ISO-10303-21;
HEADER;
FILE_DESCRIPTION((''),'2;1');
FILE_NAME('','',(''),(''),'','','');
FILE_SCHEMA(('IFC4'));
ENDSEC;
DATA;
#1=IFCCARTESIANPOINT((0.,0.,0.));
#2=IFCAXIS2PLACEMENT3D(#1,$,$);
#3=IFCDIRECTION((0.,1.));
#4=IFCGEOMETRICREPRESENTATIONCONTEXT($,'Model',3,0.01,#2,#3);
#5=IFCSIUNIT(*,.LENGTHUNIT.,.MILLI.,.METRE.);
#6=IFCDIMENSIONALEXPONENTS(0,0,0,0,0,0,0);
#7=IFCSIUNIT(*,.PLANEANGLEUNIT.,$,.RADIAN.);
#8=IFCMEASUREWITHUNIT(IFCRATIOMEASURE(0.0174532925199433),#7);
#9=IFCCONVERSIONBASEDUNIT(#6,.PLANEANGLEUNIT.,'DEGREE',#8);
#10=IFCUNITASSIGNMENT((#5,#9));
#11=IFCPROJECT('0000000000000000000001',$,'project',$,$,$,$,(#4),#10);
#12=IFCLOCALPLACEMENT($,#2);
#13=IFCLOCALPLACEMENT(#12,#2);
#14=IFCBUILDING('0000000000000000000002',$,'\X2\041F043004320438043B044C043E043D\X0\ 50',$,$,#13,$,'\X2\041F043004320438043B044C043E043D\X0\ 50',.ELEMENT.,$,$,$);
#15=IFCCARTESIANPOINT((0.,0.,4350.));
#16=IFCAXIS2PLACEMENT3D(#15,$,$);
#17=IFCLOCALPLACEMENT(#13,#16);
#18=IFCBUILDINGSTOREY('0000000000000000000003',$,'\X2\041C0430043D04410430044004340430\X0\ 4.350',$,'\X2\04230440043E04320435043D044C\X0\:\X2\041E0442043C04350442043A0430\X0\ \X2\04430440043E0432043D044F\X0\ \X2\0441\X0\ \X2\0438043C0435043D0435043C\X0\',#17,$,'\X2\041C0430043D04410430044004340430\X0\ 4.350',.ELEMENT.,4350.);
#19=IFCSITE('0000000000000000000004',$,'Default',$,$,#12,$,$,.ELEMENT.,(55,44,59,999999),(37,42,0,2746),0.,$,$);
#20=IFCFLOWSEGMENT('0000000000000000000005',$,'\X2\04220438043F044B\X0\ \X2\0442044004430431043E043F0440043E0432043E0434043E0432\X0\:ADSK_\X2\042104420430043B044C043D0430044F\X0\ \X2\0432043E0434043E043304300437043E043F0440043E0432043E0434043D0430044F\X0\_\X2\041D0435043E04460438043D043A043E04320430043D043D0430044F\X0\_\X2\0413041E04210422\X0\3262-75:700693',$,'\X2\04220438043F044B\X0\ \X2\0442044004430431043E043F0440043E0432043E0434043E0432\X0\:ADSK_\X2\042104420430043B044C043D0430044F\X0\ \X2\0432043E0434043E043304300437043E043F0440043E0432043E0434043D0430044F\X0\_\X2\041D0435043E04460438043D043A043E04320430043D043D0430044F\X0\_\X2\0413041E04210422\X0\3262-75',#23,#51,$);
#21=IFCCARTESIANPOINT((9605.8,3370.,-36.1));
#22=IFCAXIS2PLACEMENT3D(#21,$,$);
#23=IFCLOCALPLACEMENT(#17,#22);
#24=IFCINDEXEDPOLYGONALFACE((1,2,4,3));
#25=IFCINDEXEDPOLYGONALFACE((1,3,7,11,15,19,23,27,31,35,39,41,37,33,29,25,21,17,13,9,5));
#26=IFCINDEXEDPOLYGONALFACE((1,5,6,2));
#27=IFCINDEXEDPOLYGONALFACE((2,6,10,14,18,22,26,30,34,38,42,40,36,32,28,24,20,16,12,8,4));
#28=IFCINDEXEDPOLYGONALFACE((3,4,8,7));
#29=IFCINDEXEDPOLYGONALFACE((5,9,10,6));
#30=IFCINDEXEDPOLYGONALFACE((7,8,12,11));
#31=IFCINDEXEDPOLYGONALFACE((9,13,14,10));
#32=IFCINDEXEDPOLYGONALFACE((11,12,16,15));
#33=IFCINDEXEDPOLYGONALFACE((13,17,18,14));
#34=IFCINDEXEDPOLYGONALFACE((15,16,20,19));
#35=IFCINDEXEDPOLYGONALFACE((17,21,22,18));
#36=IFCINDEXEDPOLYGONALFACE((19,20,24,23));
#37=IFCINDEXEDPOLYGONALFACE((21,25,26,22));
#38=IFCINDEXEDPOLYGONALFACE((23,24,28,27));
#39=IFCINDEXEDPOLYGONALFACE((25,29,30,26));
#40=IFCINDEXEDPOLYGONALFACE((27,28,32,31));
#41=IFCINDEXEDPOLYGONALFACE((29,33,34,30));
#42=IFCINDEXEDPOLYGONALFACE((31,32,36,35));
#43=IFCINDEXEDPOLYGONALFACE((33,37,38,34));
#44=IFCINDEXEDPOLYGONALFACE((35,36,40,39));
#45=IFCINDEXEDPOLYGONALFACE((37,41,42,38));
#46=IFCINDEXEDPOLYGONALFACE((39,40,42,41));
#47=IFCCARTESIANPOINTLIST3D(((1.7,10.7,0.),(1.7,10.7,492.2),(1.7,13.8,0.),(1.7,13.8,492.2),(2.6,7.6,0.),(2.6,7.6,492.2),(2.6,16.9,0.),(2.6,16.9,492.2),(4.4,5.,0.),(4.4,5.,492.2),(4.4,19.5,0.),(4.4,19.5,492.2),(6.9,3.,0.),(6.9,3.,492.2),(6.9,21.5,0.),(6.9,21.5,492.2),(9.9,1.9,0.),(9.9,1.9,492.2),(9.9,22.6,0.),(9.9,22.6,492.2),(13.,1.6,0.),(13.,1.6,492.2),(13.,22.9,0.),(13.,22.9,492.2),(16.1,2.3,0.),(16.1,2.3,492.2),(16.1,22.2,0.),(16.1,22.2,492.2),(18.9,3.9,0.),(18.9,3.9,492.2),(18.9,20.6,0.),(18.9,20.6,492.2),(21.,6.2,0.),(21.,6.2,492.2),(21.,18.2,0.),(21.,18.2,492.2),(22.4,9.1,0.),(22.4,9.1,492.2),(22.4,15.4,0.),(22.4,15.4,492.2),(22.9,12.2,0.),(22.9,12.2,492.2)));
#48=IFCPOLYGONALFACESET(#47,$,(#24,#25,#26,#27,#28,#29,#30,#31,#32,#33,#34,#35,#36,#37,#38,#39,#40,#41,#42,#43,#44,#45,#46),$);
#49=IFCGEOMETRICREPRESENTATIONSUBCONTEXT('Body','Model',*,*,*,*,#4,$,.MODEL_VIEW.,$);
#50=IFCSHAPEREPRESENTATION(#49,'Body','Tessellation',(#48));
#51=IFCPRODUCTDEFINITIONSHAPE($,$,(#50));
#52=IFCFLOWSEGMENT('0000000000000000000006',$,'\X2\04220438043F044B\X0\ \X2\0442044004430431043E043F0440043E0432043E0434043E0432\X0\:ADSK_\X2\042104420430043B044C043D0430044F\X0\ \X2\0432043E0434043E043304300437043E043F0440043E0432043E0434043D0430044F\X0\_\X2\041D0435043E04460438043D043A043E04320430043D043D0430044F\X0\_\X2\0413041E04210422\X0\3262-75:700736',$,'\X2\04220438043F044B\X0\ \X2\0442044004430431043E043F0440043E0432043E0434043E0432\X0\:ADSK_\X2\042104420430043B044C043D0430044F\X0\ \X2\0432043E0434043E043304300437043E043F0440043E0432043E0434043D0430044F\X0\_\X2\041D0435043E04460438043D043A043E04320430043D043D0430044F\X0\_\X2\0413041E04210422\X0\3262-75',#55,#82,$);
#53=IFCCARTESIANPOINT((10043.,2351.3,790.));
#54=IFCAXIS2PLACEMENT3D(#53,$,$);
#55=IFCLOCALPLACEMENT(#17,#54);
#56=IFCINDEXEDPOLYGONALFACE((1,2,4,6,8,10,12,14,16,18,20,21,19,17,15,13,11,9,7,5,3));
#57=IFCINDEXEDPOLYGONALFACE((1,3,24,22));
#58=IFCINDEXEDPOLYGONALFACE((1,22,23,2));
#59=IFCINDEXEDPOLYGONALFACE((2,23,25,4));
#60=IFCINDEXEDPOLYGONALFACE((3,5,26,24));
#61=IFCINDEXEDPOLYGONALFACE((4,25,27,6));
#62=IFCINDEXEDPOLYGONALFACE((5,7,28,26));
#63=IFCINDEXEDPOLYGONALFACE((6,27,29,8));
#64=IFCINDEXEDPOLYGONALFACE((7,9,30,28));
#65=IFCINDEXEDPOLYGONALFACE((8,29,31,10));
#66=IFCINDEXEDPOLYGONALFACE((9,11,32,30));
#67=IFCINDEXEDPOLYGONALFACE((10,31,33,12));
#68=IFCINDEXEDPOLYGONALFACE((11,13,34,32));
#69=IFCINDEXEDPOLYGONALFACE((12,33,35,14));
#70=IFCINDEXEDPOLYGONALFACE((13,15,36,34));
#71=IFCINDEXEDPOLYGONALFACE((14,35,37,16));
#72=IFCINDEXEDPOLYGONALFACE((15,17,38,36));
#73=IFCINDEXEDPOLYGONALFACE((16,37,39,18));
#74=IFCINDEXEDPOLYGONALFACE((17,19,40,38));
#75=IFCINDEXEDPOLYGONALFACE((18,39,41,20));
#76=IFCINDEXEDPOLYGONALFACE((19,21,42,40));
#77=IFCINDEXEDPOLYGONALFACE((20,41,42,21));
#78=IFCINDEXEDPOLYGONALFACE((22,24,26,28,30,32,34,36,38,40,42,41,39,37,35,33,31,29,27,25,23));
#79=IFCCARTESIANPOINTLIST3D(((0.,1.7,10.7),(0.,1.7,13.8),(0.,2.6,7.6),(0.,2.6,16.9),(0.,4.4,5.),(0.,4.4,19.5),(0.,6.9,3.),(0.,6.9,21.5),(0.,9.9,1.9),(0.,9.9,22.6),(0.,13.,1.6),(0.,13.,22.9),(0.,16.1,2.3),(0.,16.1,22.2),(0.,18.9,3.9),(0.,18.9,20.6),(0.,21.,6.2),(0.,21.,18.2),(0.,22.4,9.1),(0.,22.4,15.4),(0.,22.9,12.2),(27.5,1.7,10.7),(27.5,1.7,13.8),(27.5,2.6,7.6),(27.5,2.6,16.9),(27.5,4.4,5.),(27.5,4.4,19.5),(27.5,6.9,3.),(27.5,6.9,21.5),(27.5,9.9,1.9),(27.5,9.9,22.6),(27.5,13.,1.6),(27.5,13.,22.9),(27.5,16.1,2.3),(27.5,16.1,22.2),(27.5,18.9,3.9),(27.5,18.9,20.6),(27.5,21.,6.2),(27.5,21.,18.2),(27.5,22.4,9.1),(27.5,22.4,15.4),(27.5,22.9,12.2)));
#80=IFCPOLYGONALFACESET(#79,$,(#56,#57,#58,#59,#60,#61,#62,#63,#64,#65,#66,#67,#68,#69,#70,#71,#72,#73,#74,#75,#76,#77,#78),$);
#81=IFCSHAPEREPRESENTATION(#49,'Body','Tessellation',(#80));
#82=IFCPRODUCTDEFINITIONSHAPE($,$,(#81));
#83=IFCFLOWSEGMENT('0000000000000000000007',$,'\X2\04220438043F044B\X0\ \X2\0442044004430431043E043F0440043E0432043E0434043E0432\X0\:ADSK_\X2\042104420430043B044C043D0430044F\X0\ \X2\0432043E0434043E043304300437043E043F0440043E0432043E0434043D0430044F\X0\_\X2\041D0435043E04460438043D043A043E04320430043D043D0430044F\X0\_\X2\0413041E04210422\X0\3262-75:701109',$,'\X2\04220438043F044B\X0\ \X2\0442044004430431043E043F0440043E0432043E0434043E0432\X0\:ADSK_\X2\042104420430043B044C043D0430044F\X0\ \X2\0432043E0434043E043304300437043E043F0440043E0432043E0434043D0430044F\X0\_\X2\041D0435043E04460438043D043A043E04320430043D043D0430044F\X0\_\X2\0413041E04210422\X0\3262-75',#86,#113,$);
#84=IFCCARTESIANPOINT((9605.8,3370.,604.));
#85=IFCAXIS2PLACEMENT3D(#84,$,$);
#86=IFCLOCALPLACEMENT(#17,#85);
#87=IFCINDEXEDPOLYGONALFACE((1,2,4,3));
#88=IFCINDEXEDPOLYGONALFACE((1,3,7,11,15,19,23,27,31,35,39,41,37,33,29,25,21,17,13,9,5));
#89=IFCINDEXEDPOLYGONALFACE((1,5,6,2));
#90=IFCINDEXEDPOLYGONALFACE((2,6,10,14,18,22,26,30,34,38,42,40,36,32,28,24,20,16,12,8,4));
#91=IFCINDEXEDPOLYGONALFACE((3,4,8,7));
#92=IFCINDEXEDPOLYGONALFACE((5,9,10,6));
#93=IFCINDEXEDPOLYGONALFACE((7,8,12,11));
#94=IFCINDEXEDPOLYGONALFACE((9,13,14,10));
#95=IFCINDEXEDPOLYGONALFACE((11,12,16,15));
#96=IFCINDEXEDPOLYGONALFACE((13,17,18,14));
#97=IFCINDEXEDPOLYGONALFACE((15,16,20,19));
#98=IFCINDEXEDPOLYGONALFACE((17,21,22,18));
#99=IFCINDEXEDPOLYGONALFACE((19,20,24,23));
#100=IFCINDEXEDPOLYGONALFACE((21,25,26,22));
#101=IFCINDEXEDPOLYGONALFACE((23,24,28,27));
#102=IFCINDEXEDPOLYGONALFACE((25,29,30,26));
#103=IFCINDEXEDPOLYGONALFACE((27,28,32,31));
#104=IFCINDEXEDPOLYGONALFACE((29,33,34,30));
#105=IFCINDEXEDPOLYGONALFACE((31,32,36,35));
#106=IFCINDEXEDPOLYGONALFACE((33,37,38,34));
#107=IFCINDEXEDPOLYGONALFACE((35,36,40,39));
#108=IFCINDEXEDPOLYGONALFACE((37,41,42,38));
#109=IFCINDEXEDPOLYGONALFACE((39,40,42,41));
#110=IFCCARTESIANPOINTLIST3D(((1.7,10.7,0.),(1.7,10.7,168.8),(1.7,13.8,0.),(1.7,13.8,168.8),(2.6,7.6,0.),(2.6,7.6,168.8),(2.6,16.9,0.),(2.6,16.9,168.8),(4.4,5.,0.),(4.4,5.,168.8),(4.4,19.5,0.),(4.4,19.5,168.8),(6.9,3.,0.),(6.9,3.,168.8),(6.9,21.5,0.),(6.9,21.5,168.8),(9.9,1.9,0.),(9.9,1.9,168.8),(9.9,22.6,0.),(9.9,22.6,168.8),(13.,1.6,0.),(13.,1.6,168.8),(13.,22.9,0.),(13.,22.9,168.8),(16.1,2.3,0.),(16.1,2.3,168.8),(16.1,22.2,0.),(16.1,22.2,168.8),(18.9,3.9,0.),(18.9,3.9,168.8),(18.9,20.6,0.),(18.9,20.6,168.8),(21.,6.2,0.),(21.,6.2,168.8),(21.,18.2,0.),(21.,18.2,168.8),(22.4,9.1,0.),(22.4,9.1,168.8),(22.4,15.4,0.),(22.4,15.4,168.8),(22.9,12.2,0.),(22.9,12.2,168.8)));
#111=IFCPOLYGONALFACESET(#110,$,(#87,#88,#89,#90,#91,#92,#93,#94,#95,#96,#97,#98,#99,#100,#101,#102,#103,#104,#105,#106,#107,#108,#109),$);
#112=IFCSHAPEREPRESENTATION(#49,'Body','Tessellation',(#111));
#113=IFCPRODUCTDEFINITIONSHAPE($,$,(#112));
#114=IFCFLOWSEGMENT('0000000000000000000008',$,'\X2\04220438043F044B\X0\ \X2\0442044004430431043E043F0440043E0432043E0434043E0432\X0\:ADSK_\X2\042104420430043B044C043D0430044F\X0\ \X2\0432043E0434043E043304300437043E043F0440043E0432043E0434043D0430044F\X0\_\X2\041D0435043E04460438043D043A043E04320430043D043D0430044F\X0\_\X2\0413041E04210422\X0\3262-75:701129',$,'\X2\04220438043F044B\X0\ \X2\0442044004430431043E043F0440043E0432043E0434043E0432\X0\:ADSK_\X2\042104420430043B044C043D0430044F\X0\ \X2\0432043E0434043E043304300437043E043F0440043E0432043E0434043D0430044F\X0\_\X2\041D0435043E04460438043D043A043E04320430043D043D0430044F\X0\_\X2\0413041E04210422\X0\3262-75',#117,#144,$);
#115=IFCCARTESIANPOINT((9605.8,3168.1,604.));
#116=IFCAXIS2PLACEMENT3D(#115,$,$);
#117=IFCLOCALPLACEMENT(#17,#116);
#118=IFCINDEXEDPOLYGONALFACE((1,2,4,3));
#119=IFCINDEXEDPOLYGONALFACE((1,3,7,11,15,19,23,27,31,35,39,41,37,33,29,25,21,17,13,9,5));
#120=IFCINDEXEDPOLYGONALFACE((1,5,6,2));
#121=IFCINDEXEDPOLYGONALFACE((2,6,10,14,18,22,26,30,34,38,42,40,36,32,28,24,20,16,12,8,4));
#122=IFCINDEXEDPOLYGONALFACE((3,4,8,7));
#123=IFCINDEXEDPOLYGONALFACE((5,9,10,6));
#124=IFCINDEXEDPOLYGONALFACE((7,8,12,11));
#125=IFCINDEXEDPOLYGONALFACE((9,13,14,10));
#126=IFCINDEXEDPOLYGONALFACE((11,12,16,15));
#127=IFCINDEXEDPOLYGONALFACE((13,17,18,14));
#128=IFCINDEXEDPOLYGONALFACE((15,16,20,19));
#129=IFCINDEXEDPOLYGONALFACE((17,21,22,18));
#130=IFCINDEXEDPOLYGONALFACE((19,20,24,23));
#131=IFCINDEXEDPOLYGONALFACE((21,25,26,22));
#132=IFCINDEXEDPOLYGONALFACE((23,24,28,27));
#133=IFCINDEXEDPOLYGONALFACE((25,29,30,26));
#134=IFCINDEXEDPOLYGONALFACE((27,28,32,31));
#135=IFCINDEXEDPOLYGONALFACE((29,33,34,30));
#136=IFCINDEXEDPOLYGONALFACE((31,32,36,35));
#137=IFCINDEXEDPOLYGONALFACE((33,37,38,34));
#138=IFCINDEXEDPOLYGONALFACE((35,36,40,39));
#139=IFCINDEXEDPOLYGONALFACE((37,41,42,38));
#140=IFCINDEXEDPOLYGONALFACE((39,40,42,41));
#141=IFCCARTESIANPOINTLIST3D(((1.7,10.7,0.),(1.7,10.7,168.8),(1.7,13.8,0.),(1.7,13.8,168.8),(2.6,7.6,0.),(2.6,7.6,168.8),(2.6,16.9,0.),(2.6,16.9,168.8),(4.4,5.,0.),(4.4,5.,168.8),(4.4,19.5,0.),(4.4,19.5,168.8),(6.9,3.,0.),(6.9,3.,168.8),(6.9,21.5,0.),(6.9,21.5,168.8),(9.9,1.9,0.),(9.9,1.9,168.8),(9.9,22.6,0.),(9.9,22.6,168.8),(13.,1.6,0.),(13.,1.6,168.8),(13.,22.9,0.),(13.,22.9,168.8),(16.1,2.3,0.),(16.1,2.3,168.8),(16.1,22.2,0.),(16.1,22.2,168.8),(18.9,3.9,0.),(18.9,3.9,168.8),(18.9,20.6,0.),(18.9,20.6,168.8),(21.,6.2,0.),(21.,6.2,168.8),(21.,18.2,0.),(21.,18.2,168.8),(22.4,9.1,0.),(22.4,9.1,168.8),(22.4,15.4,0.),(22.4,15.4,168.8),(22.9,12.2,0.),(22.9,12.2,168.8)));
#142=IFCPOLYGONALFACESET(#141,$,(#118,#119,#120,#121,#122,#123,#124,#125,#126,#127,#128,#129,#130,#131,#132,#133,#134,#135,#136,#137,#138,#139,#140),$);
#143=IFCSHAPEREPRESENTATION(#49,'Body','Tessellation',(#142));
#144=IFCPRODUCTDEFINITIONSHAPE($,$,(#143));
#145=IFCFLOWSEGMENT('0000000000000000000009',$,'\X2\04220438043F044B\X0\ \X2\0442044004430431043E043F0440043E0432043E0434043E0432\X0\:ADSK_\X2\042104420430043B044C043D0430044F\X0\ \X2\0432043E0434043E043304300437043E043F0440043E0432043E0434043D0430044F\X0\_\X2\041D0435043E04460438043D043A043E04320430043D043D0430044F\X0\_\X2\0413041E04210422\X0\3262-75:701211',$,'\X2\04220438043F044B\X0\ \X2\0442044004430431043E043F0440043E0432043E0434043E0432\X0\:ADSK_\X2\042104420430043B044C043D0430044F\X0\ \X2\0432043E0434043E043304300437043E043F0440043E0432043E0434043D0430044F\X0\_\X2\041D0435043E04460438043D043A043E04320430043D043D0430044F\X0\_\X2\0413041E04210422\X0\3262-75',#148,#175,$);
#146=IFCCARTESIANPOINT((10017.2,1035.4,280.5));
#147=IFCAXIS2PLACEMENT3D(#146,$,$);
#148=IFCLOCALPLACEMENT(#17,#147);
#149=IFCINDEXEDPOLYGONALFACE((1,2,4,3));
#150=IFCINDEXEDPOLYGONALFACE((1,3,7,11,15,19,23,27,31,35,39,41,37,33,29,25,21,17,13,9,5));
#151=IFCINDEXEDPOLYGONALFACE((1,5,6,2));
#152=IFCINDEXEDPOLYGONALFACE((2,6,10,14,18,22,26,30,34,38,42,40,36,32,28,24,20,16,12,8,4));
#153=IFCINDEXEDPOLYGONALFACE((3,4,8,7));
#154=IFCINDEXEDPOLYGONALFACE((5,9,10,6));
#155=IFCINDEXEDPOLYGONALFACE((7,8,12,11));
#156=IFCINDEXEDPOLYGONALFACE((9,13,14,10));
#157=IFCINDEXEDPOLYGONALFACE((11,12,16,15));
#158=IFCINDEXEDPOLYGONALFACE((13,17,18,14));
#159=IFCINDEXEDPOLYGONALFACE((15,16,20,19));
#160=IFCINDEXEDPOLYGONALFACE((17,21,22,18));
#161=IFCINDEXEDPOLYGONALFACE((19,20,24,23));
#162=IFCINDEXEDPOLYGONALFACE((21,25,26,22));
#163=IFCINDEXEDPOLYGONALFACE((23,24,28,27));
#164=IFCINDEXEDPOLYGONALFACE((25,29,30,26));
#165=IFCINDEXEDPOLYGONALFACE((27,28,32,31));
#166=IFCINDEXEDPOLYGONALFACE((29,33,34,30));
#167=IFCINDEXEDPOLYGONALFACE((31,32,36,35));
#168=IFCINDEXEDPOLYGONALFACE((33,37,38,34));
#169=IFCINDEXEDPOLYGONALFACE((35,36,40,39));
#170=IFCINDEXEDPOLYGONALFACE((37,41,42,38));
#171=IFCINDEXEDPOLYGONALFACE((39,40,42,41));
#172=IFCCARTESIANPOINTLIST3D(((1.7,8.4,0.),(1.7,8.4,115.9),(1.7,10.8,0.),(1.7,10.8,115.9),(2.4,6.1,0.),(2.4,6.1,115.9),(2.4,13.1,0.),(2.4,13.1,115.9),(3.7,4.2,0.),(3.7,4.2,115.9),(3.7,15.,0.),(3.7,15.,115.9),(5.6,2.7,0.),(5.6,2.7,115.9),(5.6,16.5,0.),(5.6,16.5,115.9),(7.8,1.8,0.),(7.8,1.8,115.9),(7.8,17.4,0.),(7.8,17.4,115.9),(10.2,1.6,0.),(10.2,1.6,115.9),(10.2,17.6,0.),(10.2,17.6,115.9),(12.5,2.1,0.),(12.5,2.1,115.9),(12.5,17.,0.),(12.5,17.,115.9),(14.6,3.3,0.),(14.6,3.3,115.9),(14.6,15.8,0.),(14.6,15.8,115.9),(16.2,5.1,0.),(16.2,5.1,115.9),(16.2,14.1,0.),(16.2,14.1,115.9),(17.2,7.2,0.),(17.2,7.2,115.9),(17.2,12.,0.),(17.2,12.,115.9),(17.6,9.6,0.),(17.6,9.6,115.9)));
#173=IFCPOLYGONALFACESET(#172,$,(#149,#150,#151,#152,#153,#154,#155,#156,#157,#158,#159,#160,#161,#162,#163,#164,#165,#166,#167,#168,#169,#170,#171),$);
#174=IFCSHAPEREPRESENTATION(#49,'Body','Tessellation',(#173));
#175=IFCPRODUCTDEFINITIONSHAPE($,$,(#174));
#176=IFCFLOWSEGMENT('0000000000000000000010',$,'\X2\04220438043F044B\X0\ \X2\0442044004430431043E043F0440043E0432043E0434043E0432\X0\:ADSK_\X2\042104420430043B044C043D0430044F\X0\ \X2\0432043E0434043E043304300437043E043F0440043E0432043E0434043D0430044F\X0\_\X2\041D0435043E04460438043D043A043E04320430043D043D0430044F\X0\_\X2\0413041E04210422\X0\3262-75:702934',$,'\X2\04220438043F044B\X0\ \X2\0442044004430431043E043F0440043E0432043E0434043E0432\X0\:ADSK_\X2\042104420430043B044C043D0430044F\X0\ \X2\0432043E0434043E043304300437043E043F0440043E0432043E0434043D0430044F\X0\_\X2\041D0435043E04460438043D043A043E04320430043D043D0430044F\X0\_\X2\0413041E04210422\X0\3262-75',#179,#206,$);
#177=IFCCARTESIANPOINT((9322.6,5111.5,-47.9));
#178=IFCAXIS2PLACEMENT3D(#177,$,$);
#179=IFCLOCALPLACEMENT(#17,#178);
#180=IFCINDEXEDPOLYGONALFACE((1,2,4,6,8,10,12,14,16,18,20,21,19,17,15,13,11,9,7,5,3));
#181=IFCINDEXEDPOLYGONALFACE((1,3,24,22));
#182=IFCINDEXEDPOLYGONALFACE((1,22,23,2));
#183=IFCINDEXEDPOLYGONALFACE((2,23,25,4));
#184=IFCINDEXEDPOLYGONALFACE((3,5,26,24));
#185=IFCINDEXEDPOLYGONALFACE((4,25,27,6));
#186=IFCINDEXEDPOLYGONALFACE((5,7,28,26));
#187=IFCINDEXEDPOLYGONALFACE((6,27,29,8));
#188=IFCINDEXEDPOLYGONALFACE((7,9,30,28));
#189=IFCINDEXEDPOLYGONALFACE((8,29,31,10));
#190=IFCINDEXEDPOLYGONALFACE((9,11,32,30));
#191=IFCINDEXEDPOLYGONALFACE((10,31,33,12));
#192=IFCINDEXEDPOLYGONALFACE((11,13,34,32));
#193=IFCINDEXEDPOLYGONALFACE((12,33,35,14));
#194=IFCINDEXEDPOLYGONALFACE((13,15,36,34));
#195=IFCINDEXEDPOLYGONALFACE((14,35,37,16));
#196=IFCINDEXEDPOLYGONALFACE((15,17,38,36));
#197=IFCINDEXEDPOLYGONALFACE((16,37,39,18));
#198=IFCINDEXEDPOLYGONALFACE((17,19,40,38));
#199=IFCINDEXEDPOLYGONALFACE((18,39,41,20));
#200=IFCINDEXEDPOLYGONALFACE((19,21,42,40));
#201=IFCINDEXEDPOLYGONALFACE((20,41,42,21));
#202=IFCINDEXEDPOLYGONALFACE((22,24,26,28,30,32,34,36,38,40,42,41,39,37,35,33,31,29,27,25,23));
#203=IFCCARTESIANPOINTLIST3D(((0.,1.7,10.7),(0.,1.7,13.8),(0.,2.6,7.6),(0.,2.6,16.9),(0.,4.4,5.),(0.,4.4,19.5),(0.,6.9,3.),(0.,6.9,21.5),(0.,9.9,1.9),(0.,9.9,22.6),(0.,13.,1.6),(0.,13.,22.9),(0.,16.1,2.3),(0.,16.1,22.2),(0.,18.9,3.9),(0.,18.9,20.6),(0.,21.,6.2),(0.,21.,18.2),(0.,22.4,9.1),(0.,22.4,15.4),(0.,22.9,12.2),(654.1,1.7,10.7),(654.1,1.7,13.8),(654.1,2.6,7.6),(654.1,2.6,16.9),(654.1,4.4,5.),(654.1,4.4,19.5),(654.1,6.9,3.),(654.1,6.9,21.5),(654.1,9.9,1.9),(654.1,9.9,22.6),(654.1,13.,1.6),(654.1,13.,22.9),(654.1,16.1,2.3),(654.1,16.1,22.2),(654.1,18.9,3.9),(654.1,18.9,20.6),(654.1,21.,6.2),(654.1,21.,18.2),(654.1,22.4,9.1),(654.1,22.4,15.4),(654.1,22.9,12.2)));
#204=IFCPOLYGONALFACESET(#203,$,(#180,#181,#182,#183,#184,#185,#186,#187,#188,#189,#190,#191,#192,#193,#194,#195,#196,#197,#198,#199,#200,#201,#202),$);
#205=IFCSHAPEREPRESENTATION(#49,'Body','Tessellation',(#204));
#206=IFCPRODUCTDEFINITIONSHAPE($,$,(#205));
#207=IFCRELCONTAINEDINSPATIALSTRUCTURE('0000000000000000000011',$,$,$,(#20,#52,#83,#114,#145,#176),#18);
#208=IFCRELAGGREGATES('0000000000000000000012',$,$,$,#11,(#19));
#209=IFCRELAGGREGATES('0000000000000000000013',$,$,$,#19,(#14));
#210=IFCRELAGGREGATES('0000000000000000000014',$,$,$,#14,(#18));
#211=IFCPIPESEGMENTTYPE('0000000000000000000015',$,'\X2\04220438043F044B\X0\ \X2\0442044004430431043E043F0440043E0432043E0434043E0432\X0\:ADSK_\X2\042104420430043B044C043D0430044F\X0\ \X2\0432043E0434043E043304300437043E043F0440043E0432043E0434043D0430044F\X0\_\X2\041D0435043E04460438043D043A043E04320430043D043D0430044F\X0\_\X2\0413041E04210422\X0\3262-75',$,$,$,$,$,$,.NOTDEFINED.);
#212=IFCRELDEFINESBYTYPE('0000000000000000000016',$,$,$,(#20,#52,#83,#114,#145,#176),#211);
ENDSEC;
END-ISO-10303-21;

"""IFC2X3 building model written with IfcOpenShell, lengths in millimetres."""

from ifc_helpers import new_model, entity, si_unit, converted_unit, direction, frame, frame_2d, origin, origin_2d_with_axis, place, context, subcontext, project, spatial, circle, extrude, type_object, element, save


model = new_model("IFC2X3")

# Units and contexts
model_context = context("Model", 3, precision=0.01, world=origin(), true_north=direction((0.0, 1.0)))
body_context = subcontext(model_context, "Body", "Model", "MODEL_VIEW")
ifc_project = project(units=[si_unit("LENGTHUNIT", "METRE", prefix="MILLI"), converted_unit("PLANEANGLEUNIT", "DEGREE", entity("IfcRatioMeasure", 0.0174532925199433), si_unit("PLANEANGLEUNIT", "RADIAN"), dimensions=[0, 0, 0, 0, 0, 0, 0])], contexts=[model_context])

# Site, building, storey
site_placement = place(None, origin())
site = spatial("IfcSite", under=ifc_project, at=site_placement, Name="Default", CompositionType="ELEMENT", RefLatitude=(55, 44, 59, 999999), RefLongitude=(37, 42, 0, 2746), RefElevation=0.0)
building_placement = place(site_placement, origin())
building = spatial("IfcBuilding", under=site, at=building_placement, Name="Павильон 50", LongName="Павильон 50", CompositionType="ELEMENT")
storey_placement = place(building_placement, frame((0.0, 0.0, 4350.0)))
storey = spatial("IfcBuildingStorey", under=building, at=storey_placement, Name="Мансарда 4.350", ObjectType="Уровень:Отметка уровня с именем", LongName="Мансарда 4.350", CompositionType="ELEMENT", Elevation=4350.0)

# Flow segments
pipe_segment_type = type_object("IfcPipeSegmentType", Name="Типы трубопроводов:ADSK_Стальная водогазопроводная_Неоцинкованная_ГОСТ3262-75", PredefinedType="NOTDEFINED")
flow_segment_1_placement = place(storey_placement, frame((9605.8, 3370.0, -36.1)))
element("IfcFlowSegment", 1, at=flow_segment_1_placement, inside=storey, type_object=pipe_segment_type, Name="Типы трубопроводов:ADSK_Стальная водогазопроводная_Неоцинкованная_ГОСТ3262-75:700693", ObjectType="Типы трубопроводов:ADSK_Стальная водогазопроводная_Неоцинкованная_ГОСТ3262-75", context=body_context, shape_type="SweptSolid", body=[
    extrude(circle(Radius=10.7, at=origin_2d_with_axis()), frame((12.2, 12.2, 0.0)), (0.0, 0.0, 1.0), 492.2),
])
flow_segment_2_placement = place(storey_placement, frame((10043.0, 2351.3, 790.0)))
element("IfcFlowSegment", 2, at=flow_segment_2_placement, inside=storey, type_object=pipe_segment_type, Name="Типы трубопроводов:ADSK_Стальная водогазопроводная_Неоцинкованная_ГОСТ3262-75:700736", ObjectType="Типы трубопроводов:ADSK_Стальная водогазопроводная_Неоцинкованная_ГОСТ3262-75", context=body_context, shape_type="SweptSolid", body=[
    extrude(circle(Radius=10.7, at=origin_2d_with_axis()), frame((0.0, 12.2, 12.2), z_axis=(1.0, 0.0, 0.0), x_axis=(0.0, 1.0, 0.0)), (0.0, 0.0, 1.0), 27.5),
])
flow_segment_3_placement = place(storey_placement, frame((9605.8, 3370.0, 604.0)))
element("IfcFlowSegment", 3, at=flow_segment_3_placement, inside=storey, type_object=pipe_segment_type, Name="Типы трубопроводов:ADSK_Стальная водогазопроводная_Неоцинкованная_ГОСТ3262-75:701109", ObjectType="Типы трубопроводов:ADSK_Стальная водогазопроводная_Неоцинкованная_ГОСТ3262-75", context=body_context, shape_type="SweptSolid", body=[
    extrude(circle(Radius=10.7, at=origin_2d_with_axis()), frame((12.2, 12.2, 0.0)), (0.0, 0.0, 1.0), 168.8),
])
flow_segment_4_placement = place(storey_placement, frame((9605.8, 3168.1, 604.0)))
element("IfcFlowSegment", 4, at=flow_segment_4_placement, inside=storey, type_object=pipe_segment_type, Name="Типы трубопроводов:ADSK_Стальная водогазопроводная_Неоцинкованная_ГОСТ3262-75:701129", ObjectType="Типы трубопроводов:ADSK_Стальная водогазопроводная_Неоцинкованная_ГОСТ3262-75", context=body_context, shape_type="SweptSolid", body=[
    extrude(circle(Radius=10.7, at=origin_2d_with_axis()), frame((12.2, 12.2, 0.0)), (0.0, 0.0, 1.0), 168.8),
])
flow_segment_5_placement = place(storey_placement, frame((10017.2, 1035.4, 280.5)))
element("IfcFlowSegment", 5, at=flow_segment_5_placement, inside=storey, type_object=pipe_segment_type, Name="Типы трубопроводов:ADSK_Стальная водогазопроводная_Неоцинкованная_ГОСТ3262-75:701211", ObjectType="Типы трубопроводов:ADSK_Стальная водогазопроводная_Неоцинкованная_ГОСТ3262-75", context=body_context, shape_type="SweptSolid", body=[
    extrude(circle(Radius=8.0, at=origin_2d_with_axis()), frame((9.6, 9.6, 0.0)), (0.0, 0.0, 1.0), 115.9),
])
flow_segment_6_placement = place(storey_placement, frame((9322.6, 5111.5, -47.9)))
element("IfcFlowSegment", 6, at=flow_segment_6_placement, inside=storey, type_object=pipe_segment_type, Name="Типы трубопроводов:ADSK_Стальная водогазопроводная_Неоцинкованная_ГОСТ3262-75:702934", ObjectType="Типы трубопроводов:ADSK_Стальная водогазопроводная_Неоцинкованная_ГОСТ3262-75", context=body_context, shape_type="SweptSolid", body=[
    extrude(circle(Radius=10.7, at=frame_2d((0.0, 0.0), x_axis=(1.0, 0.0))), frame((0.0, 12.2, 12.2), z_axis=(1.0, 0.0, 0.0), x_axis=(0.0, 1.0, 0.0)), (0.0, 0.0, 1.0), 654.1),
])

save(model, "model.ifc")
